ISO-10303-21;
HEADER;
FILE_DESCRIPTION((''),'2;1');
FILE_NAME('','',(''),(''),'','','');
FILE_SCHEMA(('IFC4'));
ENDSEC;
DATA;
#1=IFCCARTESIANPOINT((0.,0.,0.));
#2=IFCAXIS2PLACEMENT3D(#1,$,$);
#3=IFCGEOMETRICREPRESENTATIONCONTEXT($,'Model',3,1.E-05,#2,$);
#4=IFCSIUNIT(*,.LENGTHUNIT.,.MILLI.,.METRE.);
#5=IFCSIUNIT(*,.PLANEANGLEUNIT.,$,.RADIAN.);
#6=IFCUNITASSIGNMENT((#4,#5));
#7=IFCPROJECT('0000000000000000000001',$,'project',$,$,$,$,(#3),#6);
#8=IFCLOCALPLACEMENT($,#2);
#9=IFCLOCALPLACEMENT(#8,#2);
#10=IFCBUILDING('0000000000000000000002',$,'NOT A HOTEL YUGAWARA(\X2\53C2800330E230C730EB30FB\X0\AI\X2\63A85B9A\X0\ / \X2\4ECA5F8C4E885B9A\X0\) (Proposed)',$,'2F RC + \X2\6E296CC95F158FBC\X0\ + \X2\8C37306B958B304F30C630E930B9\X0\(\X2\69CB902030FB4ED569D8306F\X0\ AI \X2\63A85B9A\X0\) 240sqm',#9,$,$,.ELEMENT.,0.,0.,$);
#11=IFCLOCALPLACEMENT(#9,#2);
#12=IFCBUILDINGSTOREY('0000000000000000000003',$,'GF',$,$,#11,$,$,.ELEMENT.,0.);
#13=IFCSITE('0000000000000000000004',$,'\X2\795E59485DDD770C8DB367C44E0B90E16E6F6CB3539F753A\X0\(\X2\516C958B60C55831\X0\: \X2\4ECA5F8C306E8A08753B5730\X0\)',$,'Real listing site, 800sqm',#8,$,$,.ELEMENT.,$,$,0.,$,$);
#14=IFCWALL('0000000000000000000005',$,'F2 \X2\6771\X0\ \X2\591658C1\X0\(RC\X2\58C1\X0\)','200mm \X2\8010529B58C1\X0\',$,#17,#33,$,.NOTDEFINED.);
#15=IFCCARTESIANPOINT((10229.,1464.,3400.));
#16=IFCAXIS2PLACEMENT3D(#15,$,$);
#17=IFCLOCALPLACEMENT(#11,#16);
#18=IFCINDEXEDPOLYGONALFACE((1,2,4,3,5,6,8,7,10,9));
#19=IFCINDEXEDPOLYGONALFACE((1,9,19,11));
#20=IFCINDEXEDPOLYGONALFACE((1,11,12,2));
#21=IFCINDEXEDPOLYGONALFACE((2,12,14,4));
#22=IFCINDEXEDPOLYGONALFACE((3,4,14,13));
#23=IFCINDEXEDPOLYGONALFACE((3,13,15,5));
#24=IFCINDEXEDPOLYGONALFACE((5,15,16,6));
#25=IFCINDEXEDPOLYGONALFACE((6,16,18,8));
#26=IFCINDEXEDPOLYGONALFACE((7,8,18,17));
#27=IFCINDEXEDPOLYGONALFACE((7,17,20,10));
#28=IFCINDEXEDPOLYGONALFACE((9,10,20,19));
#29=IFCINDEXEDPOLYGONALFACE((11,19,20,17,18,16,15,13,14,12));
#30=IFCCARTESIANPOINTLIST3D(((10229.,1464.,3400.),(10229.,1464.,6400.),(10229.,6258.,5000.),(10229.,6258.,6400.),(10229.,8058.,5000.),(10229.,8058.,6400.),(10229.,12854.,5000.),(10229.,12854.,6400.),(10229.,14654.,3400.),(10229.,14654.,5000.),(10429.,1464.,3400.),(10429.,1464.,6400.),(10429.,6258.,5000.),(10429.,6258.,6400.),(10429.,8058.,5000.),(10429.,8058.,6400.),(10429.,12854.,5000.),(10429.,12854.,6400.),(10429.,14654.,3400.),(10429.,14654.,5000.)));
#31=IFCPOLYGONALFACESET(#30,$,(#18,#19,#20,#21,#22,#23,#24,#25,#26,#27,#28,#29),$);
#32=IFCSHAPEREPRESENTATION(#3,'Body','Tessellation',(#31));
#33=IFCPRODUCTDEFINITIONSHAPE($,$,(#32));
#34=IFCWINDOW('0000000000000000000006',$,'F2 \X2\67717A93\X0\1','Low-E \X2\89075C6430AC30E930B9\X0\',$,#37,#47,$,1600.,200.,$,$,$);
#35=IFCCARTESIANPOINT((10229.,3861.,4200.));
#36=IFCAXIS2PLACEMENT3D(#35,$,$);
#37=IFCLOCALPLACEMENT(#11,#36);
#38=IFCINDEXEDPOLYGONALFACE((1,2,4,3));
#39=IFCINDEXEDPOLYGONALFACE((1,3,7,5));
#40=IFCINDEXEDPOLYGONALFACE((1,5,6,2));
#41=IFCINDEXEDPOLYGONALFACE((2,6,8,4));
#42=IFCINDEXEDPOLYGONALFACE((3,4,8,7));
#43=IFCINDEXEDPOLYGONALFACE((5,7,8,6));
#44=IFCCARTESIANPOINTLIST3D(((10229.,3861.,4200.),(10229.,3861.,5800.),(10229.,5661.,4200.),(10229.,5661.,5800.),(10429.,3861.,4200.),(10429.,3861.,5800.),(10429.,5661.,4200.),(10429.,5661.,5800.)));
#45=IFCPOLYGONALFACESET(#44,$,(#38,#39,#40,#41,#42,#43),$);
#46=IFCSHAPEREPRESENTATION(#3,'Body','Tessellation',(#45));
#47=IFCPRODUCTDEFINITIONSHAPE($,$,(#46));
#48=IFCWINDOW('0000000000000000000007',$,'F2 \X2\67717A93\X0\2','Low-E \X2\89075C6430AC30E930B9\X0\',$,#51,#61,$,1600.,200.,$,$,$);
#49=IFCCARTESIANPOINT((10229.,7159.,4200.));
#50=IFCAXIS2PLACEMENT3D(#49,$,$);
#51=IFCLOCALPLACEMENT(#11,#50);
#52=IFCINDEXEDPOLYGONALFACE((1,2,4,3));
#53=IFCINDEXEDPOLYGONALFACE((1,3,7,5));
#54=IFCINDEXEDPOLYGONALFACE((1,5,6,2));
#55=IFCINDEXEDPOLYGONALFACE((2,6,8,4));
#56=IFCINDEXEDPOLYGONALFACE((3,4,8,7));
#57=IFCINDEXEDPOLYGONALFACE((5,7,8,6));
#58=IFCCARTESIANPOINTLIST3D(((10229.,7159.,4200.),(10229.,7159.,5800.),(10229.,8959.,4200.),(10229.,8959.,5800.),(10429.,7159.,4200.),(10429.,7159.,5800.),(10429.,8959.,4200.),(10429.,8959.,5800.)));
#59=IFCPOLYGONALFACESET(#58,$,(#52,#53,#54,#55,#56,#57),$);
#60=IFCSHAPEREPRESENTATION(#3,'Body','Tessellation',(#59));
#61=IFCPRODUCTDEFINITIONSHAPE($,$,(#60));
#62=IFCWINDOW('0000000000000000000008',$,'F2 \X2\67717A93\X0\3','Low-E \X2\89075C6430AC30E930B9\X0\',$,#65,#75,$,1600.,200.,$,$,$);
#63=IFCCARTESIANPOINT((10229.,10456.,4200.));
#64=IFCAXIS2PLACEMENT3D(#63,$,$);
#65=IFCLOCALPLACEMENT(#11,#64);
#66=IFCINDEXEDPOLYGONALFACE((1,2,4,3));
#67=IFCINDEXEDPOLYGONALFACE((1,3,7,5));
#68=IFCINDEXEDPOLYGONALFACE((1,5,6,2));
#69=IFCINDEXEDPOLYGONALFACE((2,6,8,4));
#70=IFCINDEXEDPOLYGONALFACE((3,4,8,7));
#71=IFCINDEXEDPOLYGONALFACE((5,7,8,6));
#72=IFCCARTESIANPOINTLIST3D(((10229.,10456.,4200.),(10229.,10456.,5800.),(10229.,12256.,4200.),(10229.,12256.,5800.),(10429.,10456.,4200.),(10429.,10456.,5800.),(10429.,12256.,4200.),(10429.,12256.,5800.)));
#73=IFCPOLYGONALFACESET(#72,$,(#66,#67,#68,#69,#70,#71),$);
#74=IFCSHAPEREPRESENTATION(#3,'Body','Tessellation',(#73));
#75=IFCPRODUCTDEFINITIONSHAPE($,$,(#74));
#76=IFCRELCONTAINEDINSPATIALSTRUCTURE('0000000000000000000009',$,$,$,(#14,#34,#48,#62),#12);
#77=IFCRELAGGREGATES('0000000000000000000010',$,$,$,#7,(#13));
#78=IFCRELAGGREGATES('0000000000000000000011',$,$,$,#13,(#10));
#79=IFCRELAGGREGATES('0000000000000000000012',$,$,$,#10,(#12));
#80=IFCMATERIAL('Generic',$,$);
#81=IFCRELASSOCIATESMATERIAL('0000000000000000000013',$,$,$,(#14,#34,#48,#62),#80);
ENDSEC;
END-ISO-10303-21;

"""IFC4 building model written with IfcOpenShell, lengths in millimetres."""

from ifc_helpers import new_model, si_unit, frame, frame_2d, origin, place, context, project, spatial, rectangle, extrude, material, element, fill, save


model = new_model("IFC4")

# Units and contexts
model_context = context("Model", 3, precision=1e-05, world=origin())
ifc_project = project(units=[si_unit("LENGTHUNIT", "METRE", prefix="MILLI"), si_unit("PLANEANGLEUNIT", "RADIAN")], contexts=[model_context])

# Site, building, storey
site_placement = place(None, origin())
site = spatial("IfcSite", under=ifc_project, at=site_placement, Name="神奈川県足柄下郡湯河原町(公開情報: 今後の計画地)", ObjectType="Real listing site, 800sqm", CompositionType="ELEMENT", RefElevation=0.0)
building_placement = place(site_placement, origin())
building = spatial("IfcBuilding", under=site, at=building_placement, Name="NOT A HOTEL YUGAWARA(参考モデル・AI推定 / 今後予定) (Proposed)", ObjectType="2F RC + 温泉引込 + 谷に開くテラス(構造・仕様は AI 推定) 240sqm", CompositionType="ELEMENT", ElevationOfRefHeight=0.0, ElevationOfTerrain=0.0)
storey_placement = place(building_placement, origin())
storey = spatial("IfcBuildingStorey", under=building, at=storey_placement, Name="GF", CompositionType="ELEMENT", Elevation=0.0)

# Shared definitions
ifc_material_1 = material(Name="Generic")

# Wall, openings, windows
wall_1_placement = place(storey_placement, frame((10229.0, 1464.0, 3400.0)))
wall_1 = element("IfcWall", 1, at=wall_1_placement, inside=storey, material=ifc_material_1, Name="F2 東 外壁(RC壁)", Description="200mm 耐力壁", PredefinedType="NOTDEFINED", context=model_context, shape_type="SweptSolid", body=[
    extrude(rectangle(XDim=200.0, YDim=13190.0, at=frame_2d((100.0, 6595.0))), frame((10229.0, 1464.0, 3400.0)), (0.0, 0.0, 1.0), 3000.0),
])
opening_1_placement = place(storey_placement, frame((10229.0, 3861.0, 4200.0)))
opening_1 = element("IfcOpeningElement", 2, at=opening_1_placement, cuts=wall_1, PredefinedType="NOTDEFINED", context=model_context, shape_type="SweptSolid", body=[
    extrude(rectangle(XDim=200.0, YDim=1800.0, at=frame_2d((100.0, 900.0))), frame((10229.0, 3861.0, 4200.0)), (0.0, 0.0, 1.0), 1600.0),
])
opening_2_placement = place(storey_placement, frame((10229.0, 7159.0, 4200.0)))
opening_2 = element("IfcOpeningElement", 3, at=opening_2_placement, cuts=wall_1, PredefinedType="NOTDEFINED", context=model_context, shape_type="SweptSolid", body=[
    extrude(rectangle(XDim=200.0, YDim=1800.0, at=frame_2d((100.0, 900.0))), frame((10229.0, 7159.0, 4200.0)), (0.0, 0.0, 1.0), 1600.0),
])
opening_3_placement = place(storey_placement, frame((10229.0, 10456.0, 4200.0)))
opening_3 = element("IfcOpeningElement", 4, at=opening_3_placement, cuts=wall_1, PredefinedType="NOTDEFINED", context=model_context, shape_type="SweptSolid", body=[
    extrude(rectangle(XDim=200.0, YDim=1800.0, at=frame_2d((100.0, 900.0))), frame((10229.0, 10456.0, 4200.0)), (0.0, 0.0, 1.0), 1600.0),
])
window_1_placement = place(storey_placement, frame((10229.0, 3861.0, 4200.0)))
window_1 = element("IfcWindow", 5, at=window_1_placement, inside=storey, material=ifc_material_1, Name="F2 東窓1", Description="Low-E 複層ガラス", OverallHeight=1600.0, OverallWidth=200.0, context=model_context, shape_type="SweptSolid", body=[
    extrude(rectangle(XDim=200.0, YDim=1800.0, at=frame_2d((100.0, 900.0))), frame((10229.0, 3861.0, 4200.0)), (0.0, 0.0, 1.0), 1600.0),
])
fill(opening_1, window_1)
window_2_placement = place(storey_placement, frame((10229.0, 7159.0, 4200.0)))
window_2 = element("IfcWindow", 6, at=window_2_placement, inside=storey, material=ifc_material_1, Name="F2 東窓2", Description="Low-E 複層ガラス", OverallHeight=1600.0, OverallWidth=200.0, context=model_context, shape_type="SweptSolid", body=[
    extrude(rectangle(XDim=200.0, YDim=1800.0, at=frame_2d((100.0, 900.0))), frame((10229.0, 7159.0, 4200.0)), (0.0, 0.0, 1.0), 1600.0),
])
fill(opening_2, window_2)
window_3_placement = place(storey_placement, frame((10229.0, 10456.0, 4200.0)))
window_3 = element("IfcWindow", 7, at=window_3_placement, inside=storey, material=ifc_material_1, Name="F2 東窓3", Description="Low-E 複層ガラス", OverallHeight=1600.0, OverallWidth=200.0, context=model_context, shape_type="SweptSolid", body=[
    extrude(rectangle(XDim=200.0, YDim=1800.0, at=frame_2d((100.0, 900.0))), frame((10229.0, 10456.0, 4200.0)), (0.0, 0.0, 1.0), 1600.0),
])
fill(opening_3, window_3)

save(model, "model.ifc")
